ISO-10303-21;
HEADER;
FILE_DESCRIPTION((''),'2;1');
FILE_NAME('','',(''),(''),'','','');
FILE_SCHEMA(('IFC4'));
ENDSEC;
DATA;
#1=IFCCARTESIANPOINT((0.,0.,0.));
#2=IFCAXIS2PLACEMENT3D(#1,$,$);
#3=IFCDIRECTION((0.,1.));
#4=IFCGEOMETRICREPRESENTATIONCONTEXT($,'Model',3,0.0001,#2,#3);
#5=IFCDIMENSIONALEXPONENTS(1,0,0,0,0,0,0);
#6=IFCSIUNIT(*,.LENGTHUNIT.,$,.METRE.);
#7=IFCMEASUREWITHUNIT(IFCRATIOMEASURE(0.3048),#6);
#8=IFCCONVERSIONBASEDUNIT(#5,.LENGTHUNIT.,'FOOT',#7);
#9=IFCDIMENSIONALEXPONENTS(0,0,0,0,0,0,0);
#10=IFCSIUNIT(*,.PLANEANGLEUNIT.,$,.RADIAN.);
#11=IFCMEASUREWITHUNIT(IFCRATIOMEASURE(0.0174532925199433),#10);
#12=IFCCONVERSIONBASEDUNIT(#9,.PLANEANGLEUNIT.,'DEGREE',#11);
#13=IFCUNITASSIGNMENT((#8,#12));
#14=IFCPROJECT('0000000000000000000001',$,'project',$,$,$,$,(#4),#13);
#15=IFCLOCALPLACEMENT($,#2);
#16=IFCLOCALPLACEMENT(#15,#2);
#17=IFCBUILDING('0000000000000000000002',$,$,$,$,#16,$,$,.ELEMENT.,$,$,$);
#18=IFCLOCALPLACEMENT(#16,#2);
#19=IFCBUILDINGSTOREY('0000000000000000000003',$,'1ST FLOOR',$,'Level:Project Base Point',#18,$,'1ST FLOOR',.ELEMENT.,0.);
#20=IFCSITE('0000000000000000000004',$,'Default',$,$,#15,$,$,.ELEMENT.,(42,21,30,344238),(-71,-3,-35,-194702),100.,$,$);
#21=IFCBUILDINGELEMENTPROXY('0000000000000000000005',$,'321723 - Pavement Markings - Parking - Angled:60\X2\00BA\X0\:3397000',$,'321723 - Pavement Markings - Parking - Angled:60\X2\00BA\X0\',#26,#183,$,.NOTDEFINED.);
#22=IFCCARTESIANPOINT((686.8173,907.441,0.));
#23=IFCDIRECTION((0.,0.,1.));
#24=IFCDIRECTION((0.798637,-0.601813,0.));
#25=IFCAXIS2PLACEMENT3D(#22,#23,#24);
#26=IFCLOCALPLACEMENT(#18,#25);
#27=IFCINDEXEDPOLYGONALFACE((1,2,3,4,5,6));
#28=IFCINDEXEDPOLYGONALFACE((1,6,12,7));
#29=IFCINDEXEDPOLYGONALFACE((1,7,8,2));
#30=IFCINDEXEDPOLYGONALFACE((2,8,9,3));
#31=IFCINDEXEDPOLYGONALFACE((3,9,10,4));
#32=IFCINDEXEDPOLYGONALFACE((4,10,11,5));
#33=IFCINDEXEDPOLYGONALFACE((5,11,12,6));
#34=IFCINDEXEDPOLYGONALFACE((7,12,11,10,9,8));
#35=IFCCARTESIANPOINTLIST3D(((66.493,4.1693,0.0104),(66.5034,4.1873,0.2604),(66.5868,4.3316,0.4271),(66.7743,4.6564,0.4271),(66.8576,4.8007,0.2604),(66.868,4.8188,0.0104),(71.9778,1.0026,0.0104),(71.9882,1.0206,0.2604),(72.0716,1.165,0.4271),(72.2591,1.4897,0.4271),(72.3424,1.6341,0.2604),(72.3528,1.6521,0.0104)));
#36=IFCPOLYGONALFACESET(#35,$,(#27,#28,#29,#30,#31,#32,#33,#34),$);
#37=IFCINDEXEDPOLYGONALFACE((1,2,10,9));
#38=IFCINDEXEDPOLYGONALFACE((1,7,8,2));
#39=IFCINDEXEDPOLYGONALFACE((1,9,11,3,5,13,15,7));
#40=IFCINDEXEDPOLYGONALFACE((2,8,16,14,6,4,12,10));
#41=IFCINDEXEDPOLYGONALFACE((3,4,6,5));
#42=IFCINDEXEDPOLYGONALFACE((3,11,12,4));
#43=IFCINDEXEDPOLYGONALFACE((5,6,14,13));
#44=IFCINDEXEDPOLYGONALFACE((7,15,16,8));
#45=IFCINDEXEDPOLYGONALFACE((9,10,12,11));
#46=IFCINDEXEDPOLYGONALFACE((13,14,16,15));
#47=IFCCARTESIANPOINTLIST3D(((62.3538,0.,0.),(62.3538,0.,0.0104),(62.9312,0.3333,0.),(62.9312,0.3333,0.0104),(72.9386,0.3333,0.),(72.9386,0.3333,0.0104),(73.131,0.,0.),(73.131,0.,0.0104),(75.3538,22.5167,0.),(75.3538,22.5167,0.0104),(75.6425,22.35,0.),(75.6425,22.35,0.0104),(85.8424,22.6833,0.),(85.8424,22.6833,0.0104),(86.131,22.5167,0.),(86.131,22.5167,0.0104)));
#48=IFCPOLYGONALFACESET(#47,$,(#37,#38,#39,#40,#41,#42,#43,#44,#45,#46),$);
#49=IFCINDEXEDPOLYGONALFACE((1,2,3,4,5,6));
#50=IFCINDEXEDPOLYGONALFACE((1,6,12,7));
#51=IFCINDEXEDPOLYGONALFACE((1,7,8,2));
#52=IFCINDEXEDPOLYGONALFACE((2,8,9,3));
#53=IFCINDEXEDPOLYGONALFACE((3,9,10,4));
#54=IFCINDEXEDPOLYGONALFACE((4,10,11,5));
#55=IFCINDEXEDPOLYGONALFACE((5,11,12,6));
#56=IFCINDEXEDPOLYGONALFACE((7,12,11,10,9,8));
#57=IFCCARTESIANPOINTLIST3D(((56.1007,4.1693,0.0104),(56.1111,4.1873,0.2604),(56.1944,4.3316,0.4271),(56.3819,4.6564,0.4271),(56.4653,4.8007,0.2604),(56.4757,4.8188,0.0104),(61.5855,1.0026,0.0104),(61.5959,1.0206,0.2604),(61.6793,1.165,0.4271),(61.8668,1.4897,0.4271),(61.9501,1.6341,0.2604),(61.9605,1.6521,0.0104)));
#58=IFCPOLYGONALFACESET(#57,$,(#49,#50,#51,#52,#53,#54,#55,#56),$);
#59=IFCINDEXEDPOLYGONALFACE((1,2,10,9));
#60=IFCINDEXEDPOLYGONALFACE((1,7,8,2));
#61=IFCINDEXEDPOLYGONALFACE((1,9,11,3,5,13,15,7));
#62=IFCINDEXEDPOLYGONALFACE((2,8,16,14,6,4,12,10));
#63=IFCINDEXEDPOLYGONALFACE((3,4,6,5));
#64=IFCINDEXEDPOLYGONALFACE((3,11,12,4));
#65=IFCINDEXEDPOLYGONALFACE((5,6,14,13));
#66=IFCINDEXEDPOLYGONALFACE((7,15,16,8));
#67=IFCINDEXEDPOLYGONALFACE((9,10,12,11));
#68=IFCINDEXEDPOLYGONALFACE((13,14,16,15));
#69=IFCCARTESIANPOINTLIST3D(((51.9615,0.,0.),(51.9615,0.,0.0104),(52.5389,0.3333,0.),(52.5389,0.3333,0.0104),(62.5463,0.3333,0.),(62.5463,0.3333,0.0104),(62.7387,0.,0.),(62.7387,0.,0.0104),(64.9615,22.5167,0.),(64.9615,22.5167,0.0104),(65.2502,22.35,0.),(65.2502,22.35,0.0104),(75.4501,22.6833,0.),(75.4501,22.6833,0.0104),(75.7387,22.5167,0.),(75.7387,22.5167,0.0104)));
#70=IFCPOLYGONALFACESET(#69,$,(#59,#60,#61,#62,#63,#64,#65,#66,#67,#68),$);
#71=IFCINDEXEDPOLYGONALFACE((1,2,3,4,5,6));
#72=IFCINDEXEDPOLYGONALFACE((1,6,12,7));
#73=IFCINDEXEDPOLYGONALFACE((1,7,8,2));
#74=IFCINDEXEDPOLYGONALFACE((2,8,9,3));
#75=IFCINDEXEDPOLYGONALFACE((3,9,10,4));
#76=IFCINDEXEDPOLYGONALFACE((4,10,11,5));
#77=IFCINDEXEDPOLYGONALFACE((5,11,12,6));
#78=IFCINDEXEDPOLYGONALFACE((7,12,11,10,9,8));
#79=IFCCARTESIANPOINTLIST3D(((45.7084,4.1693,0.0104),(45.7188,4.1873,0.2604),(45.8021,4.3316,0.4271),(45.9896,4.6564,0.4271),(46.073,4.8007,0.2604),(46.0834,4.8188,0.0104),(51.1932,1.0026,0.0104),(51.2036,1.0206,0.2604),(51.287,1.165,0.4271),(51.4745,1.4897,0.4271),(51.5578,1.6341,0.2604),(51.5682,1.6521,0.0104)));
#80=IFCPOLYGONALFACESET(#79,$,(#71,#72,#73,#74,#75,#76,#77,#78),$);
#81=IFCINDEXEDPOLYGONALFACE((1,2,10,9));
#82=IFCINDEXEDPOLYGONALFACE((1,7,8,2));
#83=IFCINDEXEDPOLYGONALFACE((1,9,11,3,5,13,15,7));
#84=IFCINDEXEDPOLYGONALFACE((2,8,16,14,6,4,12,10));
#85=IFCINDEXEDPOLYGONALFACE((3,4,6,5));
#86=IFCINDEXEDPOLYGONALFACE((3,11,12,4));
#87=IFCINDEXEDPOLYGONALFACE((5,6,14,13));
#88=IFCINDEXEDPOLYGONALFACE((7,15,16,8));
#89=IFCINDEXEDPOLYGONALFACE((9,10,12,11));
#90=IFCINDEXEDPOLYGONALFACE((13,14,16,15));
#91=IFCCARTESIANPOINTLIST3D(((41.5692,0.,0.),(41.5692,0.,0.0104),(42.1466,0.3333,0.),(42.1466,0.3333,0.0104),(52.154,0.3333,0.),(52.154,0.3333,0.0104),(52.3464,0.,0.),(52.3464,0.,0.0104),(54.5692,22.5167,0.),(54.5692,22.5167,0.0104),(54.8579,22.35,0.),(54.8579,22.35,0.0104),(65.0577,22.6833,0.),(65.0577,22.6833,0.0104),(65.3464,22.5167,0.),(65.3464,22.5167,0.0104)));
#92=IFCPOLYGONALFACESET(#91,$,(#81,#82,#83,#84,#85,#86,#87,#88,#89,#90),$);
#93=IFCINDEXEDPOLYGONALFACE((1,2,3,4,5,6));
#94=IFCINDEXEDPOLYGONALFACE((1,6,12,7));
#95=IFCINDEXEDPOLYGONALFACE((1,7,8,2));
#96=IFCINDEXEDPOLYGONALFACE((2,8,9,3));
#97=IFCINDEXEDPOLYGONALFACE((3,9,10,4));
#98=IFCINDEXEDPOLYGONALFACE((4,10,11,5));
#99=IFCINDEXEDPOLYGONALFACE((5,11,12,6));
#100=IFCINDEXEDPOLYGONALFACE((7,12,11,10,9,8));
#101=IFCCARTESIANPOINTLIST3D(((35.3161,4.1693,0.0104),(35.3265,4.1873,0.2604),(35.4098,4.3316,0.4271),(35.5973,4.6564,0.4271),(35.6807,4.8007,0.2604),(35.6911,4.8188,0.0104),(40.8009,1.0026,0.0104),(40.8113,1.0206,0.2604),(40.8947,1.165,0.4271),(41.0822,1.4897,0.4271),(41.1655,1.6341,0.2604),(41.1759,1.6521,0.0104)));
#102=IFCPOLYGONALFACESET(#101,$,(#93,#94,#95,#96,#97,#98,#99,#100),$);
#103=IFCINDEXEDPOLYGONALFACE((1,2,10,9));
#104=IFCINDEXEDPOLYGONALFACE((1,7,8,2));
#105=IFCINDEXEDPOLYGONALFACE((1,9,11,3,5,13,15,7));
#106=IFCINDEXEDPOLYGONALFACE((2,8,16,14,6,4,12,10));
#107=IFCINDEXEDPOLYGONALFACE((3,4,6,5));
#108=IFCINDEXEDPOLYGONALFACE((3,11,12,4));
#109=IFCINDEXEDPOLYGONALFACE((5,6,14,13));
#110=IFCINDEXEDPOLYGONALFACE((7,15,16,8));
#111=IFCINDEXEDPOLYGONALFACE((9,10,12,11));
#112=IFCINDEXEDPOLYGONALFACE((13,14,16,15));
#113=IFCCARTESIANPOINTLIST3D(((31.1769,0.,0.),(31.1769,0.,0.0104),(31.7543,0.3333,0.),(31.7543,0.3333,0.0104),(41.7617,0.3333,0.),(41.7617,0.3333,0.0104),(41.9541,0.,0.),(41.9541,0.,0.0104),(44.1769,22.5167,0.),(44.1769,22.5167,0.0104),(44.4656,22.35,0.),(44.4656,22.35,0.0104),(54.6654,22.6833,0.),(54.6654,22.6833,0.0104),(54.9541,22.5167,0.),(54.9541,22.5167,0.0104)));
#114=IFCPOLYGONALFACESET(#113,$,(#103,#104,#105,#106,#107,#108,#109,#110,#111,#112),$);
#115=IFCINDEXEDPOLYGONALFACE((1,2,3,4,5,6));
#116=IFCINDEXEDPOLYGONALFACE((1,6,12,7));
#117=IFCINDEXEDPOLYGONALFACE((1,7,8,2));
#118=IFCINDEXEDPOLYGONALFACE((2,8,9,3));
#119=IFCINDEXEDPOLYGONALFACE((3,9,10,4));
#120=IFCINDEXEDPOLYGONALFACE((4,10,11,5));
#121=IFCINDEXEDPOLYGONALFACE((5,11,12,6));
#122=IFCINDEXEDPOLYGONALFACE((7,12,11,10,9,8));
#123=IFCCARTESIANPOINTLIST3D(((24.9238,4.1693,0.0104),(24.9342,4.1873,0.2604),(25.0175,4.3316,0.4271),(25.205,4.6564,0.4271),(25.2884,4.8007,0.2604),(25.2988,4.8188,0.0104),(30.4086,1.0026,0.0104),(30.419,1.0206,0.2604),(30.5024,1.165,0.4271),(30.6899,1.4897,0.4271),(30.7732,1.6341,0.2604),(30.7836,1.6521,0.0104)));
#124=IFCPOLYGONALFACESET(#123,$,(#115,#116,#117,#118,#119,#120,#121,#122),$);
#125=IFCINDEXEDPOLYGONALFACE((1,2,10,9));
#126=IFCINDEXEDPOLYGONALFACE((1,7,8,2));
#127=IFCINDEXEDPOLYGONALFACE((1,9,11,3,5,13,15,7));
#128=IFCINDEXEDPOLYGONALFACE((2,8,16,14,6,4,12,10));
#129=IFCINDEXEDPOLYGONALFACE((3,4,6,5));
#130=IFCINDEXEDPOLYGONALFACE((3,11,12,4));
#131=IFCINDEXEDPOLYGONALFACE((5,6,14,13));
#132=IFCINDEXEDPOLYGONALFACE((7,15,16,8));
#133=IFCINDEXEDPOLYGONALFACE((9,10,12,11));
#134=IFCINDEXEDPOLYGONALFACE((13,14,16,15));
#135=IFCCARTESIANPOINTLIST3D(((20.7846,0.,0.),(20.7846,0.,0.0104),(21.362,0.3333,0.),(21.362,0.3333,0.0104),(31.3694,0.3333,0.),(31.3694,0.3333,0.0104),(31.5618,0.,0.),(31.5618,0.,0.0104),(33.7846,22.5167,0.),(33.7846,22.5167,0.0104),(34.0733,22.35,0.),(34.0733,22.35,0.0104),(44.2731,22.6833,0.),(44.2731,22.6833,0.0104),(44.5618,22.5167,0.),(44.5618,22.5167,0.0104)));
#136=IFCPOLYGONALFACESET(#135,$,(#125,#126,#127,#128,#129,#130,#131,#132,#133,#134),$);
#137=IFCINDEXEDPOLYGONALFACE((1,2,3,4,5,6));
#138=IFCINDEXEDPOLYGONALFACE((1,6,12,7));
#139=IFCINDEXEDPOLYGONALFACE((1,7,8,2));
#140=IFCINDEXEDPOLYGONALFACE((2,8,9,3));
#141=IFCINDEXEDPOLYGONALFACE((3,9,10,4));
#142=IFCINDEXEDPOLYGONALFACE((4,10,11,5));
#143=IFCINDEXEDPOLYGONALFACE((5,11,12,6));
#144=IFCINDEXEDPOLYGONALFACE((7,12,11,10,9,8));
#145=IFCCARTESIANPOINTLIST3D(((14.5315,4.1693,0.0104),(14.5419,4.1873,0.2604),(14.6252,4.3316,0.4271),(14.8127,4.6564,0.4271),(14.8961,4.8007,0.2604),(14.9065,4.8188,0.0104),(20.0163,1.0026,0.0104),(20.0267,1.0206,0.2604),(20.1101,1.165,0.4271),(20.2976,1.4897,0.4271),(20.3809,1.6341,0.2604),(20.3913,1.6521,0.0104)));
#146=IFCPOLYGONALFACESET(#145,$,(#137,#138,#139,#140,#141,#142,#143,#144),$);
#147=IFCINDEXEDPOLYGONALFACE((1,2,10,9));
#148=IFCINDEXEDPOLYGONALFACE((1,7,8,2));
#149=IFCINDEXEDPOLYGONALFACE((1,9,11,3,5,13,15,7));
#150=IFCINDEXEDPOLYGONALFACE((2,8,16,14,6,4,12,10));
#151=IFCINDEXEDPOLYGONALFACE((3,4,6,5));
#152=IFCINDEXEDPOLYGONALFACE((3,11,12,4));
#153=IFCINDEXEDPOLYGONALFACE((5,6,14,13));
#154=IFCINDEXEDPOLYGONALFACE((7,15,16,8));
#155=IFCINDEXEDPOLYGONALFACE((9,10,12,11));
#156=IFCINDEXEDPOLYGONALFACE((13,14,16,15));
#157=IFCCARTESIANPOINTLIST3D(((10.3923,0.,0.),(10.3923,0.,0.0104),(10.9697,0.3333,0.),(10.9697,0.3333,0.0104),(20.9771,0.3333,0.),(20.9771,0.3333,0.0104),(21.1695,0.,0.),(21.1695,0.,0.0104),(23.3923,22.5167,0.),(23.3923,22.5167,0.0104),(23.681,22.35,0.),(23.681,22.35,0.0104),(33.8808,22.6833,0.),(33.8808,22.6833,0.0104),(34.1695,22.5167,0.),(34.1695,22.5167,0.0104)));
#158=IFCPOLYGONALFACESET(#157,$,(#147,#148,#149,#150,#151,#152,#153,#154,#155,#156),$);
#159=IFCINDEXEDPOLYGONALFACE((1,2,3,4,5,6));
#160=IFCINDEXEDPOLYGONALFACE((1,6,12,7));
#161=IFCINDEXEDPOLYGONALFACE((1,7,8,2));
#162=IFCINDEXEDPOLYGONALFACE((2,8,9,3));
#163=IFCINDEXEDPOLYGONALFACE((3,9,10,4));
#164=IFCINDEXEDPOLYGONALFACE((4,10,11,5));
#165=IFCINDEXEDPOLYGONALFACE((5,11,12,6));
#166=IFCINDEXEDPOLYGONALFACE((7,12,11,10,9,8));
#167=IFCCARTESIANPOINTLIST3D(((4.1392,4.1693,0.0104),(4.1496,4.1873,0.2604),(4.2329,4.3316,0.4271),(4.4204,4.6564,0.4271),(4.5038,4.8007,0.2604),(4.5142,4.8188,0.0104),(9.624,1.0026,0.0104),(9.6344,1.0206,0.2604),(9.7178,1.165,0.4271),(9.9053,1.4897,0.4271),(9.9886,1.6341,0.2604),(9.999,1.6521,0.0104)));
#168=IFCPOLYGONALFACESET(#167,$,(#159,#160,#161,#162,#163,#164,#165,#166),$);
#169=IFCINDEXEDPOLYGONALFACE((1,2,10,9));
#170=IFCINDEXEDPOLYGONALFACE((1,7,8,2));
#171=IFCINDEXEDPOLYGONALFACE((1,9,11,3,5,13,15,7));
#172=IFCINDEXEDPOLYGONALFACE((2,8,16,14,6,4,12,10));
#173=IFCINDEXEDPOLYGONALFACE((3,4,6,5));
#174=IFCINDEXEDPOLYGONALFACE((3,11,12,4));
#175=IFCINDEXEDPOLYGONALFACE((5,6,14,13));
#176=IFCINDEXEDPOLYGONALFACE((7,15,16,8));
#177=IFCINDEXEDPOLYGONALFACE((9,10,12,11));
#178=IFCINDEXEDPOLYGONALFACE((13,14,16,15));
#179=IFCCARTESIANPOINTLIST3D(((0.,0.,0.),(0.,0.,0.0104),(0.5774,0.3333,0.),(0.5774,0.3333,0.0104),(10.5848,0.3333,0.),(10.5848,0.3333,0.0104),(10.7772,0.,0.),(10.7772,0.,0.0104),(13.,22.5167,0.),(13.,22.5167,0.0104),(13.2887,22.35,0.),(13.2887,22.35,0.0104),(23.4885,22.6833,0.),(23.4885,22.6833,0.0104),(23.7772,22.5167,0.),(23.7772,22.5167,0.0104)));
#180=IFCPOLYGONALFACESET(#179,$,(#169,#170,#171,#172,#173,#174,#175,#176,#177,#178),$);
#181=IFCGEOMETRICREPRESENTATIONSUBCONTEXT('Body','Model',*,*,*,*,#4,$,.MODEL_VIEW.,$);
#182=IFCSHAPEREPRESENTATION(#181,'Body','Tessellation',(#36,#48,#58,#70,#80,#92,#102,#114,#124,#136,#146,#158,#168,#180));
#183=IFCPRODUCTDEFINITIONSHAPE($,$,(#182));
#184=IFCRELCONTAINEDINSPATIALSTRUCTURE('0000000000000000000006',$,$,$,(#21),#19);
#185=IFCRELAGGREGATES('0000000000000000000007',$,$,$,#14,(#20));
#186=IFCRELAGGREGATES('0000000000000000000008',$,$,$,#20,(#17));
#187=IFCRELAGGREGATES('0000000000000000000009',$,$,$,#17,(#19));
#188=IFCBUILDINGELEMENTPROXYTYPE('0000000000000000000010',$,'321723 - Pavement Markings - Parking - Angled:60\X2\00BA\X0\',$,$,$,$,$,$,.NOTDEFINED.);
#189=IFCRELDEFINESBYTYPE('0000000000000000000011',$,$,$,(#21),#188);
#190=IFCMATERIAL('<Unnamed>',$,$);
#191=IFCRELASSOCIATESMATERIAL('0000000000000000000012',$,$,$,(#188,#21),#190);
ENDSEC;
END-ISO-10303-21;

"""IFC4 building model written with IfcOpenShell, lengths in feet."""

from ifc_helpers import new_model, entity, si_unit, converted_unit, direction, frame, origin, place, context, subcontext, project, spatial, polyline, outline, extrude, source, transform, mapped, material, type_object, type_shapes, element, save


model = new_model("IFC4")

# Units and contexts
model_context = context("Model", 3, precision=0.0001, world=origin(), true_north=direction((0.0, 1.0)))
body_context = subcontext(model_context, "Body", "Model", "MODEL_VIEW")
ifc_project = project(units=[converted_unit("LENGTHUNIT", "FOOT", entity("IfcRatioMeasure", 0.3048), si_unit("LENGTHUNIT", "METRE"), dimensions=[1, 0, 0, 0, 0, 0, 0]), converted_unit("PLANEANGLEUNIT", "DEGREE", entity("IfcRatioMeasure", 0.0174532925199433), si_unit("PLANEANGLEUNIT", "RADIAN"), dimensions=[0, 0, 0, 0, 0, 0, 0])], contexts=[model_context])

# Site, building, storey
site_placement = place(None, origin())
site = spatial("IfcSite", under=ifc_project, at=site_placement, Name="Default", CompositionType="ELEMENT", RefLatitude=(42, 21, 30, 344238), RefLongitude=(-71, -3, -35, -194702), RefElevation=100.0)
building_placement = place(site_placement, origin())
building = spatial("IfcBuilding", under=site, at=building_placement, CompositionType="ELEMENT")
storey_placement = place(building_placement, origin())
storey = spatial("IfcBuildingStorey", under=building, at=storey_placement, Name="1ST FLOOR", ObjectType="Level:Project Base Point", LongName="1ST FLOOR", CompositionType="ELEMENT", Elevation=0.0)

# Building element proxy
ifc_material_1 = material(Name="<Unnamed>")
building_element_proxy_type_1 = type_object("IfcBuildingElementProxyType", Name="321723 - Pavement Markings - Parking - Angled:60º", PredefinedType="NOTDEFINED", material=ifc_material_1)
shared_shape_1 = source(origin(), body_context, "Body", "SweptSolid", [
    extrude(outline(polyline([(-0.375, -0.2222), (0.375, -0.2222), (0.3542, 0.0278), (0.1875, 0.1944), (-0.1875, 0.1944), (-0.3542, 0.0278), (-0.375, -0.2222)])), frame((66.6805, 4.494, 0.2326), z_axis=(0.866025, -0.5, 0.0), x_axis=(0.5, 0.866025, 0.0)), (0.0, 0.0, 1.0), 6.3333),
    extrude(outline(polyline([(-11.9367, -11.3417), (-1.1595, -11.3417), (11.8405, 11.175), (11.5518, 11.3417), (-1.352, -11.0083), (-11.3594, -11.0083), (1.352, 11.0083), (1.0633, 11.175), (-11.9367, -11.3417)])), frame((74.2905, 11.3417, 0.0)), (0.0, 0.0, 1.0), 0.0104),
    extrude(outline(polyline([(-0.375, -0.2222), (0.375, -0.2222), (0.3542, 0.0278), (0.1875, 0.1944), (-0.1875, 0.1944), (-0.3542, 0.0278), (-0.375, -0.2222)])), frame((56.2882, 4.494, 0.2326), z_axis=(0.866025, -0.5, 0.0), x_axis=(0.5, 0.866025, 0.0)), (0.0, 0.0, 1.0), 6.3333),
    extrude(outline(polyline([(-11.9367, -11.3417), (-1.1595, -11.3417), (11.8405, 11.175), (11.5518, 11.3417), (-1.352, -11.0083), (-11.3594, -11.0083), (1.352, 11.0083), (1.0633, 11.175), (-11.9367, -11.3417)])), frame((63.8982, 11.3417, 0.0)), (0.0, 0.0, 1.0), 0.0104),
    extrude(outline(polyline([(-0.375, -0.2222), (0.375, -0.2222), (0.3542, 0.0278), (0.1875, 0.1944), (-0.1875, 0.1944), (-0.3542, 0.0278), (-0.375, -0.2222)])), frame((45.8959, 4.494, 0.2326), z_axis=(0.866025, -0.5, 0.0), x_axis=(0.5, 0.866025, 0.0)), (0.0, 0.0, 1.0), 6.3333),
    extrude(outline(polyline([(-11.9367, -11.3417), (-1.1595, -11.3417), (11.8405, 11.175), (11.5518, 11.3417), (-1.352, -11.0083), (-11.3594, -11.0083), (1.352, 11.0083), (1.0633, 11.175), (-11.9367, -11.3417)])), frame((53.5059, 11.3417, 0.0)), (0.0, 0.0, 1.0), 0.0104),
    extrude(outline(polyline([(-0.375, -0.2222), (0.375, -0.2222), (0.3542, 0.0278), (0.1875, 0.1944), (-0.1875, 0.1944), (-0.3542, 0.0278), (-0.375, -0.2222)])), frame((35.5036, 4.494, 0.2326), z_axis=(0.866025, -0.5, 0.0), x_axis=(0.5, 0.866025, 0.0)), (0.0, 0.0, 1.0), 6.3333),
    extrude(outline(polyline([(-11.9367, -11.3417), (-1.1595, -11.3417), (11.8405, 11.175), (11.5518, 11.3417), (-1.352, -11.0083), (-11.3594, -11.0083), (1.352, 11.0083), (1.0633, 11.175), (-11.9367, -11.3417)])), frame((43.1136, 11.3417, 0.0)), (0.0, 0.0, 1.0), 0.0104),
    extrude(outline(polyline([(-0.375, -0.2222), (0.375, -0.2222), (0.3542, 0.0278), (0.1875, 0.1944), (-0.1875, 0.1944), (-0.3542, 0.0278), (-0.375, -0.2222)])), frame((25.1113, 4.494, 0.2326), z_axis=(0.866025, -0.5, 0.0), x_axis=(0.5, 0.866025, 0.0)), (0.0, 0.0, 1.0), 6.3333),
    extrude(outline(polyline([(-11.9367, -11.3417), (-1.1595, -11.3417), (11.8405, 11.175), (11.5518, 11.3417), (-1.352, -11.0083), (-11.3594, -11.0083), (1.352, 11.0083), (1.0633, 11.175), (-11.9367, -11.3417)])), frame((32.7213, 11.3417, 0.0)), (0.0, 0.0, 1.0), 0.0104),
    extrude(outline(polyline([(-0.375, -0.2222), (0.375, -0.2222), (0.3542, 0.0278), (0.1875, 0.1944), (-0.1875, 0.1944), (-0.3542, 0.0278), (-0.375, -0.2222)])), frame((14.719, 4.494, 0.2326), z_axis=(0.866025, -0.5, 0.0), x_axis=(0.5, 0.866025, 0.0)), (0.0, 0.0, 1.0), 6.3333),
    extrude(outline(polyline([(-11.9367, -11.3417), (-1.1595, -11.3417), (11.8405, 11.175), (11.5518, 11.3417), (-1.352, -11.0083), (-11.3594, -11.0083), (1.352, 11.0083), (1.0633, 11.175), (-11.9367, -11.3417)])), frame((22.329, 11.3417, 0.0)), (0.0, 0.0, 1.0), 0.0104),
    extrude(outline(polyline([(-0.375, -0.2222), (0.375, -0.2222), (0.3542, 0.0278), (0.1875, 0.1944), (-0.1875, 0.1944), (-0.3542, 0.0278), (-0.375, -0.2222)])), frame((4.3267, 4.494, 0.2326), z_axis=(0.866025, -0.5, 0.0), x_axis=(0.5, 0.866025, 0.0)), (0.0, 0.0, 1.0), 6.3333),
    extrude(outline(polyline([(-11.9367, -11.3417), (-1.1595, -11.3417), (11.8405, 11.175), (11.5518, 11.3417), (-1.352, -11.0083), (-11.3594, -11.0083), (1.352, 11.0083), (1.0633, 11.175), (-11.9367, -11.3417)])), frame((11.9367, 11.3417, 0.0)), (0.0, 0.0, 1.0), 0.0104),
])
type_shapes(building_element_proxy_type_1, [shared_shape_1])
proxy_1_placement = place(storey_placement, frame((686.8173, 907.441, 0.0), z_axis=(0.0, 0.0, 1.0), x_axis=(0.798637, -0.601813, 0.0)))
element("IfcBuildingElementProxy", 1, at=proxy_1_placement, inside=storey, type_object=building_element_proxy_type_1, material=ifc_material_1, Name="321723 - Pavement Markings - Parking - Angled:60º:3397000", ObjectType="321723 - Pavement Markings - Parking - Angled:60º", PredefinedType="NOTDEFINED", context=body_context, shape_type="MappedRepresentation", body=[
    mapped(shared_shape_1, transform((0.0, 0.0, 0.0), scale=1.0)),
])

save(model, "model.ifc")
